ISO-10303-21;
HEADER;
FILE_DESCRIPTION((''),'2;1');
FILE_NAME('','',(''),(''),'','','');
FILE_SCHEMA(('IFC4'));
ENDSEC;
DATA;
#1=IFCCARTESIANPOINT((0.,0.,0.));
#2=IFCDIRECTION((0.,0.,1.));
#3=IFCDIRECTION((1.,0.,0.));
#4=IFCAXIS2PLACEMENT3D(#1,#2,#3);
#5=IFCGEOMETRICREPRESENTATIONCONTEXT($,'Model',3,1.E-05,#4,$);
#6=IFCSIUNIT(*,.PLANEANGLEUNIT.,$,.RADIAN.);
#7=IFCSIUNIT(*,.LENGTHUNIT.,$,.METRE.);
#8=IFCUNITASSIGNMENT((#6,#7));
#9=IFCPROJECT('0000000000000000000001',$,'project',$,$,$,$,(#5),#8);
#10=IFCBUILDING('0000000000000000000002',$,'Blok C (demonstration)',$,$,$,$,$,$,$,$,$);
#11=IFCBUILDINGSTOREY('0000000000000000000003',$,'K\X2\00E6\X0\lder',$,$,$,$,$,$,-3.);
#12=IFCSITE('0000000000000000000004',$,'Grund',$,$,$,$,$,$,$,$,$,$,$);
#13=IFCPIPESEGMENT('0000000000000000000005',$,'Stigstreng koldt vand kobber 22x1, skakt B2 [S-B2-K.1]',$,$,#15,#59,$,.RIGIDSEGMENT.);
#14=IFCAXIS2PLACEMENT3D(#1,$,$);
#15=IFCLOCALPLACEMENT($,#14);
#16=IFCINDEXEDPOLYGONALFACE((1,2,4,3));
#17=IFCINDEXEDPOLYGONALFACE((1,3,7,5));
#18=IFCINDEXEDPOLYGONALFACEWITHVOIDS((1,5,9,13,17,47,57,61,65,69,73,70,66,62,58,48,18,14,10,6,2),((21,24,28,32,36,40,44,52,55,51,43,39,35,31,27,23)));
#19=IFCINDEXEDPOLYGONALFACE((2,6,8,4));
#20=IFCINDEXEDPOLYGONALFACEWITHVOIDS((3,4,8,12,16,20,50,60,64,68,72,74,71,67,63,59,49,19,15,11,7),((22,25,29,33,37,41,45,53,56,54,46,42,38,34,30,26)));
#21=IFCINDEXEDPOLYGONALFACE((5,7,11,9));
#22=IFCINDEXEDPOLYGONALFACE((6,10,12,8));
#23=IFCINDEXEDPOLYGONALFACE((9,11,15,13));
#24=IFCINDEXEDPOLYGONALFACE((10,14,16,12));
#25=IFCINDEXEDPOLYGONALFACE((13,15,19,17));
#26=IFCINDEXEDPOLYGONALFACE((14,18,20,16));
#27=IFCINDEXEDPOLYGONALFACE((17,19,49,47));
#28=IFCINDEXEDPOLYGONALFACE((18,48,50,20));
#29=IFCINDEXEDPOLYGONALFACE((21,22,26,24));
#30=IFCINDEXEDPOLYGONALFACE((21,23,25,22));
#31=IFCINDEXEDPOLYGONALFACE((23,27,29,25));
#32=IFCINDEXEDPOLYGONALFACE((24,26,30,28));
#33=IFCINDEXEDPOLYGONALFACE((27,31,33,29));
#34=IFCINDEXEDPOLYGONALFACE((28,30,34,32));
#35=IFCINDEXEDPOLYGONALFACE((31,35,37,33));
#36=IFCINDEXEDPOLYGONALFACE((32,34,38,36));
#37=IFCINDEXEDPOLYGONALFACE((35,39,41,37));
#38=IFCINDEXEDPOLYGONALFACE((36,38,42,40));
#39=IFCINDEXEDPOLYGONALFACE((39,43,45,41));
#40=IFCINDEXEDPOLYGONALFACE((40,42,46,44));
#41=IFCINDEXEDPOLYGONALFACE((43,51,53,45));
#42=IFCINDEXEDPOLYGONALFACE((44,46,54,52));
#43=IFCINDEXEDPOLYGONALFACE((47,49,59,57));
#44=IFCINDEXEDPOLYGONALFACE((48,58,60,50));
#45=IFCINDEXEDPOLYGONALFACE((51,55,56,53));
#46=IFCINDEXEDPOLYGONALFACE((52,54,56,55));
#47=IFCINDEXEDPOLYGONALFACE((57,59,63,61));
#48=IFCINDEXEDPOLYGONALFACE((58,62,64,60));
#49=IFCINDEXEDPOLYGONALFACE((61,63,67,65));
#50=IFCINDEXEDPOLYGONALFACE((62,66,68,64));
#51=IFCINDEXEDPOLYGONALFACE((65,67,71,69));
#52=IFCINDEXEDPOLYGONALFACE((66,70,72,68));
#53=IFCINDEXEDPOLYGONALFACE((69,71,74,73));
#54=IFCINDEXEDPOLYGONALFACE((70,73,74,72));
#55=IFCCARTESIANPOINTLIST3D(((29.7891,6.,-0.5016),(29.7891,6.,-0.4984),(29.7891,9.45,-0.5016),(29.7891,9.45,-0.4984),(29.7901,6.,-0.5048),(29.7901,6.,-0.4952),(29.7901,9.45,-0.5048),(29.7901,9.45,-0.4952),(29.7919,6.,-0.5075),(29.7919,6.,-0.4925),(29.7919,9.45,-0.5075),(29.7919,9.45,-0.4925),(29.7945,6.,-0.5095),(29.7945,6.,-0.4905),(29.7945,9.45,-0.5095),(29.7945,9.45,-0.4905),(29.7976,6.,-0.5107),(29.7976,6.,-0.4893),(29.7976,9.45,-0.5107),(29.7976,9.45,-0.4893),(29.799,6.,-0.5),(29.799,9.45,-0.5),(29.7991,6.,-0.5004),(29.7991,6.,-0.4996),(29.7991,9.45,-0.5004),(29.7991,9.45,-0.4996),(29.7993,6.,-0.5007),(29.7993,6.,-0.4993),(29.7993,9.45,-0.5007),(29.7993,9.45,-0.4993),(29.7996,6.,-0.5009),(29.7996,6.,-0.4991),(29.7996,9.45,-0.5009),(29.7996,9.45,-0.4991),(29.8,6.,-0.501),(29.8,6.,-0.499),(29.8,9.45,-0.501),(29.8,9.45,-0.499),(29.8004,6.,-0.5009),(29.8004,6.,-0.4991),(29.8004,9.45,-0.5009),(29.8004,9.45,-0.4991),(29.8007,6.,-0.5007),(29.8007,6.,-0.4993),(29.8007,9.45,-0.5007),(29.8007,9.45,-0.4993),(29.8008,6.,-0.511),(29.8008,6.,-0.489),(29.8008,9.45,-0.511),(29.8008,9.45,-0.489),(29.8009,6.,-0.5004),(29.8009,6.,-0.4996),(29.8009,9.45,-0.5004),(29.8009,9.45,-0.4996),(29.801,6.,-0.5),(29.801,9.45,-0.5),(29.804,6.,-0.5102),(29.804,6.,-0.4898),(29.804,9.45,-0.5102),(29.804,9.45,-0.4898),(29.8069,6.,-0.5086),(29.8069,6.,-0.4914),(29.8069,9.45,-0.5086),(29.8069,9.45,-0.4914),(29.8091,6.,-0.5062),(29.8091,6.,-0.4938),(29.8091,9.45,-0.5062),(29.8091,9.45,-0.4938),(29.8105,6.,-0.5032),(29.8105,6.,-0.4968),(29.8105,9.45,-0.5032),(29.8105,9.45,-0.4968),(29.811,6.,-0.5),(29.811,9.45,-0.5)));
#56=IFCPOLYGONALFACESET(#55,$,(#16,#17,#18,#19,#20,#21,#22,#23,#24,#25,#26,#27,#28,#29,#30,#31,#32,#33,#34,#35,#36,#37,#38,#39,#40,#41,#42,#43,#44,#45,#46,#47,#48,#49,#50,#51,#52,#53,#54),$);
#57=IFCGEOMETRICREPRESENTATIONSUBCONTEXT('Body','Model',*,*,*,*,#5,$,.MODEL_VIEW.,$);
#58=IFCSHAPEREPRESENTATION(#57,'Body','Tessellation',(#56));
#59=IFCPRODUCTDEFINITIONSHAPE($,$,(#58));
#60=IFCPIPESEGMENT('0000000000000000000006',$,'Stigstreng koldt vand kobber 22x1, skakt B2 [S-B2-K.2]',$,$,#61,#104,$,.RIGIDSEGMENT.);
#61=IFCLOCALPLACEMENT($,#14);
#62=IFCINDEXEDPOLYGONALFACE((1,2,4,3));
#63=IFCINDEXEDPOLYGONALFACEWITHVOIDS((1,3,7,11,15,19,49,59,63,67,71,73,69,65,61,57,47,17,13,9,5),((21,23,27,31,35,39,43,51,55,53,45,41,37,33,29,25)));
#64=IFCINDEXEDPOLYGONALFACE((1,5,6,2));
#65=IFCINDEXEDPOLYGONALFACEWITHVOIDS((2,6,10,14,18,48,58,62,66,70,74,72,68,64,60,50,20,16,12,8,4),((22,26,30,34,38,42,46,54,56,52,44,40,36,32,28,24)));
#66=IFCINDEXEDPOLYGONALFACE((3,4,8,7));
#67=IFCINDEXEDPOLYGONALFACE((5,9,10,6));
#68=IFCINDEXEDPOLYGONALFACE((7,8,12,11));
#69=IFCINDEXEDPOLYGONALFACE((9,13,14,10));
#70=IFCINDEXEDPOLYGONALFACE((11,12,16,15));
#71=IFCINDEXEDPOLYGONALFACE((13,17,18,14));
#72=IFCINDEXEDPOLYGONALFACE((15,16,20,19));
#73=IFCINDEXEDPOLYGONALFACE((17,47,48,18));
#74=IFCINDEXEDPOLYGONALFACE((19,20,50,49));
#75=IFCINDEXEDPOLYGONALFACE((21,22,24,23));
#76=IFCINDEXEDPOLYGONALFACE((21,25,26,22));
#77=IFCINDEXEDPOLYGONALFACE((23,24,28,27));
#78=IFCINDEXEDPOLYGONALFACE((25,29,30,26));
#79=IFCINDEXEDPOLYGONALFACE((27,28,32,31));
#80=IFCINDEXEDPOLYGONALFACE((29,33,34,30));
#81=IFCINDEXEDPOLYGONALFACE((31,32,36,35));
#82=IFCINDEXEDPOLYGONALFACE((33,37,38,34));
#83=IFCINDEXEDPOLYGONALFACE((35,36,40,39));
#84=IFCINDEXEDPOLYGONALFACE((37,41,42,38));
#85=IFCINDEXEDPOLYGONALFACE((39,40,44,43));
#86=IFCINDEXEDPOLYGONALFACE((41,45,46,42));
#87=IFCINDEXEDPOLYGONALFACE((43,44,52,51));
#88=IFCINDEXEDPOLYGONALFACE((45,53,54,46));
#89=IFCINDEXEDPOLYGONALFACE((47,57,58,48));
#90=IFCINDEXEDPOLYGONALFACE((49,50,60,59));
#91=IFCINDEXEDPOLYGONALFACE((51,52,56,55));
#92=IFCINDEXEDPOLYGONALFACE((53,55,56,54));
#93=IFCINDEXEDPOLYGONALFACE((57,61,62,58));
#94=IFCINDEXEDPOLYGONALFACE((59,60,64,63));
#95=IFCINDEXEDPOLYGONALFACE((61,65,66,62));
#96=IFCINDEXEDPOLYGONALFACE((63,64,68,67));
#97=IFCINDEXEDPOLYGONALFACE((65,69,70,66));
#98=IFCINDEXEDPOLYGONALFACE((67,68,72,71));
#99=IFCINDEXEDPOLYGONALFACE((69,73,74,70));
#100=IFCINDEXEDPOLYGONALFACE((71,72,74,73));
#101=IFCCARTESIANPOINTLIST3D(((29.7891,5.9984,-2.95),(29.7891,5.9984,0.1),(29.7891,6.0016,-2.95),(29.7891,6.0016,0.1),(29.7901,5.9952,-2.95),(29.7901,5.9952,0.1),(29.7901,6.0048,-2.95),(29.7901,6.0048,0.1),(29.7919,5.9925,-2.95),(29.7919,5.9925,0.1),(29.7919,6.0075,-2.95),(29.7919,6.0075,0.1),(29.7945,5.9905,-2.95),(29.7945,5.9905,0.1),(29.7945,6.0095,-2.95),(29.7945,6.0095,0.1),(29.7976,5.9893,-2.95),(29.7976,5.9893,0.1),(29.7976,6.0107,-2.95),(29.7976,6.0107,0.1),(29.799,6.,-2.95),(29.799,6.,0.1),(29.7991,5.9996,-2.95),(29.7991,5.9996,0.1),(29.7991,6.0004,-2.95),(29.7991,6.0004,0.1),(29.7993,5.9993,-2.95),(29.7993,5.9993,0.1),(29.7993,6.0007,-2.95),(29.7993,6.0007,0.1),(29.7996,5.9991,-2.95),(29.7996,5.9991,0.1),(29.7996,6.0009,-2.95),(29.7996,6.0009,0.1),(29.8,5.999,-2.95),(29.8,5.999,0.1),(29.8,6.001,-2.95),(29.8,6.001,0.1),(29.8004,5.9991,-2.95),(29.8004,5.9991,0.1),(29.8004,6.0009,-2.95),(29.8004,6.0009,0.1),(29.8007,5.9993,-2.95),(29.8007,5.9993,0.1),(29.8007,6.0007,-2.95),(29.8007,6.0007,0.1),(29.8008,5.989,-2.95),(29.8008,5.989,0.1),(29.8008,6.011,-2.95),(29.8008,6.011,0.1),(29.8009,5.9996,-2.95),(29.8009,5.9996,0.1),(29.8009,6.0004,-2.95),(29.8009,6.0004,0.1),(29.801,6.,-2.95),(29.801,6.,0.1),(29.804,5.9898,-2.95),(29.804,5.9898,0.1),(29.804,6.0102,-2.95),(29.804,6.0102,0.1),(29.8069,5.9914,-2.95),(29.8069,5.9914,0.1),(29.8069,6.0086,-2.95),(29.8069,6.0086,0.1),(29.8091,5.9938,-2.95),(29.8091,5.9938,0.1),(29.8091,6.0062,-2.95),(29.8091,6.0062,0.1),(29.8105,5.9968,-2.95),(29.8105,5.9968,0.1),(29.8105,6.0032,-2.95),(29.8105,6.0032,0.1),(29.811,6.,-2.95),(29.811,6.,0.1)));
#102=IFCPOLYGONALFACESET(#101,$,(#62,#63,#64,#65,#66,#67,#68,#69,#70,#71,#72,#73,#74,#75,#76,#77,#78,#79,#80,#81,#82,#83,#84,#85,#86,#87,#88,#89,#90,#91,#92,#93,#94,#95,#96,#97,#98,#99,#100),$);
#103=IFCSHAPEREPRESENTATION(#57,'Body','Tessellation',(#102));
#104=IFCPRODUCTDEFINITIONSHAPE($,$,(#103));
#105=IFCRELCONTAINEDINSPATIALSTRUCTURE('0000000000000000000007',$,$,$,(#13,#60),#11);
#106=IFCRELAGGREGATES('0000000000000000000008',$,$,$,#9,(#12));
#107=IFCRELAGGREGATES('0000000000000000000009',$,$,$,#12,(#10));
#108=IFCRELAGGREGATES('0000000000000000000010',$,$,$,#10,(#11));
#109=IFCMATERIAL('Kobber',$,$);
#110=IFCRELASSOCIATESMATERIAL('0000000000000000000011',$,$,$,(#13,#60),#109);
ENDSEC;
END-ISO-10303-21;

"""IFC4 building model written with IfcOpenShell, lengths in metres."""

from ifc_helpers import new_model, si_unit, frame, origin_with_axes, place, context, subcontext, project, spatial, hollow_circle, extrude, material, element, save


model = new_model("IFC4")

# Units and contexts
model_context = context("Model", 3, precision=1e-05, world=origin_with_axes())
body_context = subcontext(model_context, "Body", "Model", "MODEL_VIEW")
ifc_project = project(units=[si_unit("PLANEANGLEUNIT", "RADIAN"), si_unit("LENGTHUNIT", "METRE")], contexts=[model_context])

# Site, building, storey
site = spatial("IfcSite", under=ifc_project, Name="Grund")
building = spatial("IfcBuilding", under=site, Name="Blok C (demonstration)")
storey = spatial("IfcBuildingStorey", under=building, Name="Kælder", Elevation=-3.0)

# Pipe segments
ifc_material_1 = material(Name="Kobber")
pipe_segment_1_placement = place(None, origin_with_axes())
element("IfcPipeSegment", 1, at=pipe_segment_1_placement, inside=storey, material=ifc_material_1, Name="Stigstreng koldt vand kobber 22x1, skakt B2 [S-B2-K.1]", PredefinedType="RIGIDSEGMENT", context=body_context, shape_type="SweptSolid", body=[
    extrude(hollow_circle(Radius=0.011, WallThickness=0.01), frame((29.8, 9.45, -0.5), z_axis=(0.0, -1.0, 0.0), x_axis=(1.0, 0.0, 0.0)), (0.0, 0.0, 1.0), 3.45),
])
pipe_segment_2_placement = place(None, origin_with_axes())
element("IfcPipeSegment", 2, at=pipe_segment_2_placement, inside=storey, material=ifc_material_1, Name="Stigstreng koldt vand kobber 22x1, skakt B2 [S-B2-K.2]", PredefinedType="RIGIDSEGMENT", context=body_context, shape_type="SweptSolid", body=[
    extrude(hollow_circle(Radius=0.011, WallThickness=0.01), frame((29.8, 6.0, -2.95), z_axis=(0.0, 0.0, 1.0), x_axis=(1.0, 0.0, 0.0)), (0.0, 0.0, 1.0), 3.05),
])

save(model, "model.ifc")
